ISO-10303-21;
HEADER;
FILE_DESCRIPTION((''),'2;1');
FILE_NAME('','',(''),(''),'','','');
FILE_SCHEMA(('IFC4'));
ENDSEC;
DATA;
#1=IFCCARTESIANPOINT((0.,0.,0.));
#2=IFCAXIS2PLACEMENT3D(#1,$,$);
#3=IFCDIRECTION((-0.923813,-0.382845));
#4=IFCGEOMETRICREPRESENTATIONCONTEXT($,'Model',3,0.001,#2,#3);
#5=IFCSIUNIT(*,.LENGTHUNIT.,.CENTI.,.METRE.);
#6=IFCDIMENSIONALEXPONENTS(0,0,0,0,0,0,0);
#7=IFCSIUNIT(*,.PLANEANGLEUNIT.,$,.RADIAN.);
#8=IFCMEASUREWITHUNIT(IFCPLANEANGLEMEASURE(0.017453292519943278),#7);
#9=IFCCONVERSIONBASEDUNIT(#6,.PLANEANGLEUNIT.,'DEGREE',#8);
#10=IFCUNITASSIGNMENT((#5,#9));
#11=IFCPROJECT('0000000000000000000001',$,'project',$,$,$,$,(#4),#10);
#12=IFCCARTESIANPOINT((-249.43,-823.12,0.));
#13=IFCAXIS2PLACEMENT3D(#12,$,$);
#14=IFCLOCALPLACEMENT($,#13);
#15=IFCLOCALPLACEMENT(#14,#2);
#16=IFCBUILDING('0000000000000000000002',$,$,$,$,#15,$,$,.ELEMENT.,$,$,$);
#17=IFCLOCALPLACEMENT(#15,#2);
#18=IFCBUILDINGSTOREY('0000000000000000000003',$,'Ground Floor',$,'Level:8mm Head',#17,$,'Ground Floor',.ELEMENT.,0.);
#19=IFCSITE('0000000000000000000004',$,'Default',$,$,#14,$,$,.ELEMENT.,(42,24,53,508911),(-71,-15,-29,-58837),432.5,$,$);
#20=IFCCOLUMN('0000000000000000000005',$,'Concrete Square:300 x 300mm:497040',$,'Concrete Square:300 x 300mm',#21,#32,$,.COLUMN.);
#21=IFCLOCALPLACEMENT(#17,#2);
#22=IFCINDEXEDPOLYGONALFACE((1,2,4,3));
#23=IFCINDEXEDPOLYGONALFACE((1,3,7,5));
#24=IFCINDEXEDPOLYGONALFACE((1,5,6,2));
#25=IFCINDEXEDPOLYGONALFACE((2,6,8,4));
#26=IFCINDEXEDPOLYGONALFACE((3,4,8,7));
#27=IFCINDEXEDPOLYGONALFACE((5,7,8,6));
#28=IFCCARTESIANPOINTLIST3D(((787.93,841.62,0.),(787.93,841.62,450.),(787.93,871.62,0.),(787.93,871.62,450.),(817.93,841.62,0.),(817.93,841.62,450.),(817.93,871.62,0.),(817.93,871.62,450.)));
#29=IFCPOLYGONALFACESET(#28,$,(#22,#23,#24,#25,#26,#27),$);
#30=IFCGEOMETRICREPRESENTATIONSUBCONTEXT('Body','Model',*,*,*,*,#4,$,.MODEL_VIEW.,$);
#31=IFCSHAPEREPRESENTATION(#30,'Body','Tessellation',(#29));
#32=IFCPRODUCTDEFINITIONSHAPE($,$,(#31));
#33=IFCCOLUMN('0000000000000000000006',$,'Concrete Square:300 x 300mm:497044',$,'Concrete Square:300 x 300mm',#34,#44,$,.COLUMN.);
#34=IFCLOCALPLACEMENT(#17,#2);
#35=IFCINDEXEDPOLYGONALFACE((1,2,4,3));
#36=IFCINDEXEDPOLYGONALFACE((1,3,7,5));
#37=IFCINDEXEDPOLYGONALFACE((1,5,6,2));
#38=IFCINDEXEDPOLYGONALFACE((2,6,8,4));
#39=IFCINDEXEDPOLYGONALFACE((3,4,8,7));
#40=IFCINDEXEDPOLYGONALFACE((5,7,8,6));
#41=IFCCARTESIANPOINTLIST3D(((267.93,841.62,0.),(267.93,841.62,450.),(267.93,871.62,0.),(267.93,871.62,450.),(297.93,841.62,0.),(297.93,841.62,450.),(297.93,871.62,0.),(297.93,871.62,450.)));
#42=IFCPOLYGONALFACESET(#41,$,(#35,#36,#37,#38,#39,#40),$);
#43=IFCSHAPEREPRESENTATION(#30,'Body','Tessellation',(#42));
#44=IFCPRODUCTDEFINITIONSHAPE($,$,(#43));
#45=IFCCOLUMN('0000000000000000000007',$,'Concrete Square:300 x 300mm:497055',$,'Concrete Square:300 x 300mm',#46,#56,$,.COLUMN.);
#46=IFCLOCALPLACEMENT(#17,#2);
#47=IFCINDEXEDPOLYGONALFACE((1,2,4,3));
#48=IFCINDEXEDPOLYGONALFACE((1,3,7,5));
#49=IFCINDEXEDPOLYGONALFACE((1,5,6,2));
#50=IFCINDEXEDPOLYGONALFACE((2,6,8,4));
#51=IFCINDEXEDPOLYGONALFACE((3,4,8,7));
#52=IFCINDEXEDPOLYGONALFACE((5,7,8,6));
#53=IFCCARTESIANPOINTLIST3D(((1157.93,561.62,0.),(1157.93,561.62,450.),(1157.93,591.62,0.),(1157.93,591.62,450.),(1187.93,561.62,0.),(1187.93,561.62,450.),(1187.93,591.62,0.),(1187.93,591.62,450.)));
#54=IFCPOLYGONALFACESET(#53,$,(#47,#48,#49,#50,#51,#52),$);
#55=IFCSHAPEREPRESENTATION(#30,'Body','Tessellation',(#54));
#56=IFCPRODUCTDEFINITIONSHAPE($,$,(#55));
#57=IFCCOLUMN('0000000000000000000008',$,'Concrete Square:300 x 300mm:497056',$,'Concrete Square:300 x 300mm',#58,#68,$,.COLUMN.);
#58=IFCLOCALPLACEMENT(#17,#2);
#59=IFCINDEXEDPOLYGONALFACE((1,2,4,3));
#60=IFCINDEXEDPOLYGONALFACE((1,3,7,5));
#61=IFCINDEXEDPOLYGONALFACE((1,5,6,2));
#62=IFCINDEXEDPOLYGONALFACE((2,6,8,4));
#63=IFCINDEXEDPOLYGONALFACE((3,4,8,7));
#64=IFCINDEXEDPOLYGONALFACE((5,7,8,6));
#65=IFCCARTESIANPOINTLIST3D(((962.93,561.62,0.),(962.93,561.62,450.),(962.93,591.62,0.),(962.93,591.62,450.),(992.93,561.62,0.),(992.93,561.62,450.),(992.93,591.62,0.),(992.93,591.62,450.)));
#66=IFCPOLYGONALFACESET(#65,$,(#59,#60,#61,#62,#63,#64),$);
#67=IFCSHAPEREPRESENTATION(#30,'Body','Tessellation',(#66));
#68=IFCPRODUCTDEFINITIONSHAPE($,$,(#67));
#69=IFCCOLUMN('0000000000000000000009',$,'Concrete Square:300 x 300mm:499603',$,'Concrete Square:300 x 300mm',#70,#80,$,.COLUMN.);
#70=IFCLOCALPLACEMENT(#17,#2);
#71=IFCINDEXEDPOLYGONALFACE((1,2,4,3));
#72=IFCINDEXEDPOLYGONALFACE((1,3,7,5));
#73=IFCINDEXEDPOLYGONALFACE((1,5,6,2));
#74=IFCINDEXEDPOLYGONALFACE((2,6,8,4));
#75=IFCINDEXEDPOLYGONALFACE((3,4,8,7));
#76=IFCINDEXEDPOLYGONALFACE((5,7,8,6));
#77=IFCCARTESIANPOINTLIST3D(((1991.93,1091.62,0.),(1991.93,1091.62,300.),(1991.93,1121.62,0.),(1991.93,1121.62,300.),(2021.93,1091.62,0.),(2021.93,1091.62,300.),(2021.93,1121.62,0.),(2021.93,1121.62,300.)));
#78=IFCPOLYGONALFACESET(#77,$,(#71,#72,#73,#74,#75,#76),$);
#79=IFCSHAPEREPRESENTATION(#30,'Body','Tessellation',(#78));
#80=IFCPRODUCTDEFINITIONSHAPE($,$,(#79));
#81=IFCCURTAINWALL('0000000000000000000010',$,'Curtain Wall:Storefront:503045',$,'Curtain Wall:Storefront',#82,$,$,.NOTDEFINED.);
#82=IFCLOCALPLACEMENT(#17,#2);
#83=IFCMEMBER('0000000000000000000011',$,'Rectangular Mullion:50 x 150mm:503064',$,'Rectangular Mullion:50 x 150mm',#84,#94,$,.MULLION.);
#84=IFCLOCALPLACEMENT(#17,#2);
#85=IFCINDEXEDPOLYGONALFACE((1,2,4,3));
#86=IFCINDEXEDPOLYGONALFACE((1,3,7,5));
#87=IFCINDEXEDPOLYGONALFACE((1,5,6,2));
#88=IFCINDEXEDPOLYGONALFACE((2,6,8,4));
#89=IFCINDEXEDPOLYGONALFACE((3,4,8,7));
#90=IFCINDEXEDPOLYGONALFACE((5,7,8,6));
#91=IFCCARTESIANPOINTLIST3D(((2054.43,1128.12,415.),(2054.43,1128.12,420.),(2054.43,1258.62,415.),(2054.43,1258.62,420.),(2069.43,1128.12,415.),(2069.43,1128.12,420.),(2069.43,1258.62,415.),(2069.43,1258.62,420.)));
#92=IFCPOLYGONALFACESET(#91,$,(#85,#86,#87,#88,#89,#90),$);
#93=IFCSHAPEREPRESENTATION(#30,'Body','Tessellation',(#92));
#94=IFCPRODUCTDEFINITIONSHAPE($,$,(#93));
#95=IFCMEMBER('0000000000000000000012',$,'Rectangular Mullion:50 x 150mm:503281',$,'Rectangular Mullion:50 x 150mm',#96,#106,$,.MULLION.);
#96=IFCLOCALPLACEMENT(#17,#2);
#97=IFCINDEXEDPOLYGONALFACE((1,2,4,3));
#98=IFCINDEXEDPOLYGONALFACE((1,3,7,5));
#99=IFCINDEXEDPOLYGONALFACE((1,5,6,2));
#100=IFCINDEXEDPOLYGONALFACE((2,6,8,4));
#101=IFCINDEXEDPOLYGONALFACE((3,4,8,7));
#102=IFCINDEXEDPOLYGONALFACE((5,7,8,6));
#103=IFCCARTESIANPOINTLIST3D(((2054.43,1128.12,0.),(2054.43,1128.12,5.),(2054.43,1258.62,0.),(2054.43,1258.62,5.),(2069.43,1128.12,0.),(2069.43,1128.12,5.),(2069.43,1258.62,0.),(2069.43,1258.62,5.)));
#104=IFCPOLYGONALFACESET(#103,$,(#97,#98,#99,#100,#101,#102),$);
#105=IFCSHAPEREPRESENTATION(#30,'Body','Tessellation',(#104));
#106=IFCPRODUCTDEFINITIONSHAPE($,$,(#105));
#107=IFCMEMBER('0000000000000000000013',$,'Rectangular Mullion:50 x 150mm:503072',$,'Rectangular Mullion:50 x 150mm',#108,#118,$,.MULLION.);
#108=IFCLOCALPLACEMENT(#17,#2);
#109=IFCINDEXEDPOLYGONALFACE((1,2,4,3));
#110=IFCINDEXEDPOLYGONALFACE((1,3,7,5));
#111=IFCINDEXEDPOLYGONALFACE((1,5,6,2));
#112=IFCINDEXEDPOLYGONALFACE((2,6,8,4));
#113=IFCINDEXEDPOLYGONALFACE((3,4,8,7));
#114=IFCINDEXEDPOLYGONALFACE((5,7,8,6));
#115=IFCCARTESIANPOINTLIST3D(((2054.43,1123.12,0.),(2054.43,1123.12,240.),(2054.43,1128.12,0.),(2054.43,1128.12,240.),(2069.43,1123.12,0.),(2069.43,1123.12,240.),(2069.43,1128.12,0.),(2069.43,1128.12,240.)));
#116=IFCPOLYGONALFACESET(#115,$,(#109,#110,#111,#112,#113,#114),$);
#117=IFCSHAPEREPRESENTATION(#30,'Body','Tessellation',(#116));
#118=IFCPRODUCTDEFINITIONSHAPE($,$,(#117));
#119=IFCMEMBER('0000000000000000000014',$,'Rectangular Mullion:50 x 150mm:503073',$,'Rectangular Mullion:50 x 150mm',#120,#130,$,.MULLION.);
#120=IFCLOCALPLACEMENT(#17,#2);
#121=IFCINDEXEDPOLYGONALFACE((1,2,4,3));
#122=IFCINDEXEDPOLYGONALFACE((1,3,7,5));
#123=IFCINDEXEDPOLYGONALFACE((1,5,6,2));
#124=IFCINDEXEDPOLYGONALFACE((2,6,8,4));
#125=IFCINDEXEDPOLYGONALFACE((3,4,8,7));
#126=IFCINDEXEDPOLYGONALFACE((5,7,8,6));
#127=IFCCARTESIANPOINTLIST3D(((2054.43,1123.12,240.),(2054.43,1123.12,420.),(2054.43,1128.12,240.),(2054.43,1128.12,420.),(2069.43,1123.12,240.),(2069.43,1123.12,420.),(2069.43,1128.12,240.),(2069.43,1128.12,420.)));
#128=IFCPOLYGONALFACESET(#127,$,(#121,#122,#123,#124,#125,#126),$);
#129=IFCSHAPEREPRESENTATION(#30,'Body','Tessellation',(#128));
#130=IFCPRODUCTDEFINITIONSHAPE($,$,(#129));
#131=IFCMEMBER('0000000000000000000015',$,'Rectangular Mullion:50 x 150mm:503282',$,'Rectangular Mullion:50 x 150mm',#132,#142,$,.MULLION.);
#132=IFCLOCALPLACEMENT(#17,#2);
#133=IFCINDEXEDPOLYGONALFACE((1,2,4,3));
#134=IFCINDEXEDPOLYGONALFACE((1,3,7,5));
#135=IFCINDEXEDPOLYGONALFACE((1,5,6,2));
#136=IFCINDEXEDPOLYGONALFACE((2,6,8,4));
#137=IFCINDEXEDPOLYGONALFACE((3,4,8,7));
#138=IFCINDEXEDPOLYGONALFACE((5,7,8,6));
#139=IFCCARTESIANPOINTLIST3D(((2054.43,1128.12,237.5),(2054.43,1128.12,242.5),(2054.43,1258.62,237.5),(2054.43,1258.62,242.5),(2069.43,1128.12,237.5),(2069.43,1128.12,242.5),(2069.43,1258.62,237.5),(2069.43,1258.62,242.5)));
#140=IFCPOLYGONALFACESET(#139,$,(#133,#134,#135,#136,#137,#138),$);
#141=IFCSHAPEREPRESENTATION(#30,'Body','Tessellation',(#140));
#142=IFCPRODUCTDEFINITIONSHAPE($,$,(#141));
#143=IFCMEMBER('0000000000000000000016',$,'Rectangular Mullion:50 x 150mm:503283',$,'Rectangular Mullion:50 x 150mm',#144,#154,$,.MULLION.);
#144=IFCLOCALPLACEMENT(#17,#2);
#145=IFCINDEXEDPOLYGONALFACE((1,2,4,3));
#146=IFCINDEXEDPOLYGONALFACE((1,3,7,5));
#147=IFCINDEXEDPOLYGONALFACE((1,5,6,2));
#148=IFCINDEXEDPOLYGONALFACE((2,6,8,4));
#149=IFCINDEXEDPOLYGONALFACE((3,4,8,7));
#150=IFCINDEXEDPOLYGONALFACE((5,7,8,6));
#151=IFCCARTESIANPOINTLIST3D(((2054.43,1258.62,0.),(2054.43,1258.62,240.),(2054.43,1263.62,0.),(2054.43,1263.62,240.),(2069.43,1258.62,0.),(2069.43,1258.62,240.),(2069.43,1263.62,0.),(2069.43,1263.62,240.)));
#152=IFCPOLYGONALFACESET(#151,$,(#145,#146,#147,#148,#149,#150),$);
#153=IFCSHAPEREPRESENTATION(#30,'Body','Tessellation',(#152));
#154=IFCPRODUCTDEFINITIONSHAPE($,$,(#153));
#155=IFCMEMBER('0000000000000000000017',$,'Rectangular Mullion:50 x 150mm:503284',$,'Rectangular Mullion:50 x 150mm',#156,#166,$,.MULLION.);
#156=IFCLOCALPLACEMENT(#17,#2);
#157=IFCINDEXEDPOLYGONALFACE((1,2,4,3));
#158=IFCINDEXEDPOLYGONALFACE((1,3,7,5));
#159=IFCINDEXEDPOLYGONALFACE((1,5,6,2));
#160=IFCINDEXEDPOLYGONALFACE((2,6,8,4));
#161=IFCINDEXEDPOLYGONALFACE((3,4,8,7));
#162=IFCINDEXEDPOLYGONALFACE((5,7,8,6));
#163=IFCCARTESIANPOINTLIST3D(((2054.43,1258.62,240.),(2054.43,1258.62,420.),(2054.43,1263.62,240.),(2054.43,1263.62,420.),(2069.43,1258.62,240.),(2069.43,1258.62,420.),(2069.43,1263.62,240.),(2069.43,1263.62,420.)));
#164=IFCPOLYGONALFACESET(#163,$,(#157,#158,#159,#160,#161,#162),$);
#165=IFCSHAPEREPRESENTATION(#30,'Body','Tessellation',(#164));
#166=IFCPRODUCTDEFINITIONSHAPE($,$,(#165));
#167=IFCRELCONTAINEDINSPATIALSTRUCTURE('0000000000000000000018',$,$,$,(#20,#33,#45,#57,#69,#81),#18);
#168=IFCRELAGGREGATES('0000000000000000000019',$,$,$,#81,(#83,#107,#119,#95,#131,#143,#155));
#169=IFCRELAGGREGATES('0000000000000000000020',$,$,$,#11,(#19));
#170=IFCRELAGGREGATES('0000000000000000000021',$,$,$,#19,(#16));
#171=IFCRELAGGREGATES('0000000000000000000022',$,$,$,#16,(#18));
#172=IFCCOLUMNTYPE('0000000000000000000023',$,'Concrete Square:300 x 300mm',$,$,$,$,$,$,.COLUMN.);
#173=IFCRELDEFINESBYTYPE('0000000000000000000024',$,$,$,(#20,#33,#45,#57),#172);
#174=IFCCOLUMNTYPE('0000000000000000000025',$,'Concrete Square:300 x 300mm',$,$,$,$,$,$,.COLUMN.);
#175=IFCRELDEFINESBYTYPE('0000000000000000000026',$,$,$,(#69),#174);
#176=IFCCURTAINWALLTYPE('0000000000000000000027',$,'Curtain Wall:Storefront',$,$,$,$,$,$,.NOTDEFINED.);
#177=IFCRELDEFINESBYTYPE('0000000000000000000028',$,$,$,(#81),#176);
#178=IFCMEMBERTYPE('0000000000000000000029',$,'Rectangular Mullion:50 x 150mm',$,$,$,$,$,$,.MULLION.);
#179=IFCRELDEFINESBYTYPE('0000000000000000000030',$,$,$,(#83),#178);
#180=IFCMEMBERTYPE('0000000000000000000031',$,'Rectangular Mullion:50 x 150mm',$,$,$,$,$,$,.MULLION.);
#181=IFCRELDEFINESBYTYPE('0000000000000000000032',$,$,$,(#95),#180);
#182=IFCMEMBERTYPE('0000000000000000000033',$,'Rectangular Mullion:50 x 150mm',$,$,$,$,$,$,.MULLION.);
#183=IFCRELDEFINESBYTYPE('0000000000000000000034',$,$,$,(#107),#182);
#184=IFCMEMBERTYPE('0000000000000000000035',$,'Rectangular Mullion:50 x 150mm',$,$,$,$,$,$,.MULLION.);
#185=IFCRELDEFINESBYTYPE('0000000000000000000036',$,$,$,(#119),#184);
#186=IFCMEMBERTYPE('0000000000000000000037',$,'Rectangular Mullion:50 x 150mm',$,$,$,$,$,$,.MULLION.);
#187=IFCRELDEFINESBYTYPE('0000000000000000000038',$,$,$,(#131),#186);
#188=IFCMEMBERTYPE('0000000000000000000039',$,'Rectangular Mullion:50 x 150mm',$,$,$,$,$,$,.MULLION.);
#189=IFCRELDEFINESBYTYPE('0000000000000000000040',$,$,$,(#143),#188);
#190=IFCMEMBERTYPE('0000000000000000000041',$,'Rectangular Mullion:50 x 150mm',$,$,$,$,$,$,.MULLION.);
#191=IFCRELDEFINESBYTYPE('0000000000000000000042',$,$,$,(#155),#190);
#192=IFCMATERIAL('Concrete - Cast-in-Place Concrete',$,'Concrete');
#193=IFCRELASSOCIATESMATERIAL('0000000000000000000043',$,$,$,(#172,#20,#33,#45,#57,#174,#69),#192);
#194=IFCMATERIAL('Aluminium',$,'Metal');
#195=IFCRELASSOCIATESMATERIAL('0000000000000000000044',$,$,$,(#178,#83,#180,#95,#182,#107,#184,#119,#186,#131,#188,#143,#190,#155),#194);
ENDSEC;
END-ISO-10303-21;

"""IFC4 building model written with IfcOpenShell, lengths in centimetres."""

from ifc_helpers import new_model, entity, si_unit, converted_unit, direction, frame, origin, place, context, subcontext, project, spatial, indexed_curve, outline, extrude, source, transform, mapped, material, type_object, type_shapes, element, aggregate, save


model = new_model("IFC4")

# Units and contexts
model_context = context("Model", 3, precision=0.001, world=origin(), true_north=direction((-0.923813, -0.382845)))
body_context = subcontext(model_context, "Body", "Model", "MODEL_VIEW")
ifc_project = project(units=[si_unit("LENGTHUNIT", "METRE", prefix="CENTI"), converted_unit("PLANEANGLEUNIT", "DEGREE", entity("IfcPlaneAngleMeasure", 0.017453292519943278), si_unit("PLANEANGLEUNIT", "RADIAN"), dimensions=[0, 0, 0, 0, 0, 0, 0])], contexts=[model_context])

# Site, building, storey
site_placement = place(None, frame((-249.43, -823.12, 0.0)))
site = spatial("IfcSite", under=ifc_project, at=site_placement, Name="Default", CompositionType="ELEMENT", RefLatitude=(42, 24, 53, 508911), RefLongitude=(-71, -15, -29, -58837), RefElevation=432.5)
building_placement = place(site_placement, origin())
building = spatial("IfcBuilding", under=site, at=building_placement, CompositionType="ELEMENT")
storey_placement = place(building_placement, origin())
storey = spatial("IfcBuildingStorey", under=building, at=storey_placement, Name="Ground Floor", ObjectType="Level:8mm Head", LongName="Ground Floor", CompositionType="ELEMENT", Elevation=0.0)

# Columns
ifc_material_1 = material(Name="Concrete - Cast-in-Place Concrete", Category="Concrete")
column_type_1 = type_object("IfcColumnType", Name="Concrete Square:300 x 300mm", PredefinedType="COLUMN", material=ifc_material_1)
shared_shape_1 = source(origin(), body_context, "Body", "SweptSolid", [
    extrude(outline(indexed_curve([(-15.0, -15.0), (15.0, -15.0), (15.0, 15.0), (-15.0, 15.0), (-15.0, -15.0)], self_intersect=False)), frame((0.0, 0.0, 0.0), z_axis=(0.0, 0.0, 1.0), x_axis=(-1.0, 0.0, 0.0)), (0.0, 0.0, 1.0), 450.0),
])
type_shapes(column_type_1, [shared_shape_1])
for number, where, name in (
    (1, (802.93, 856.62, 0.0), "Concrete Square:300 x 300mm:497040"),
    (2, (282.93, 856.62, 0.0), "Concrete Square:300 x 300mm:497044"),
    (3, (1172.93, 576.62, 0.0), "Concrete Square:300 x 300mm:497055"),
    (4, (977.93, 576.62, 0.0), "Concrete Square:300 x 300mm:497056"),
):
    element("IfcColumn", number, at=place(storey_placement, frame(where)), inside=storey, type_object=column_type_1, material=ifc_material_1, Name=name, ObjectType="Concrete Square:300 x 300mm", PredefinedType="COLUMN", context=body_context, shape_type="MappedRepresentation", body=[
        mapped(shared_shape_1, transform((0.0, 0.0, 0.0), scale=1.0)),
    ])
column_type_2 = type_object("IfcColumnType", Name="Concrete Square:300 x 300mm", PredefinedType="COLUMN", material=ifc_material_1)
shared_shape_2 = source(origin(), body_context, "Body", "SweptSolid", [
    extrude(outline(indexed_curve([(-15.0, -15.0), (15.0, -15.0), (15.0, 15.0), (-15.0, 15.0), (-15.0, -15.0)], self_intersect=False)), frame((0.0, 0.0, 0.0), z_axis=(0.0, 0.0, 1.0), x_axis=(-1.0, 0.0, 0.0)), (0.0, 0.0, 1.0), 300.0),
])
type_shapes(column_type_2, [shared_shape_2])
column_placement = place(storey_placement, frame((2006.93, 1106.62, 0.0)))
element("IfcColumn", 5, at=column_placement, inside=storey, type_object=column_type_2, material=ifc_material_1, Name="Concrete Square:300 x 300mm:499603", ObjectType="Concrete Square:300 x 300mm", PredefinedType="COLUMN", context=body_context, shape_type="MappedRepresentation", body=[
    mapped(shared_shape_2, transform((0.0, 0.0, 0.0), scale=1.0)),
])

# Curtain wall, members
curtain_wall_type = type_object("IfcCurtainWallType", Name="Curtain Wall:Storefront", PredefinedType="NOTDEFINED")
curtain_wall_placement = place(storey_placement, origin())
curtain_wall = element("IfcCurtainWall", 6, at=curtain_wall_placement, inside=storey, type_object=curtain_wall_type, Name="Curtain Wall:Storefront:503045", ObjectType="Curtain Wall:Storefront", PredefinedType="NOTDEFINED")
ifc_material_2 = material(Name="Aluminium", Category="Metal")
member_type_1 = type_object("IfcMemberType", Name="Rectangular Mullion:50 x 150mm", PredefinedType="MULLION", material=ifc_material_2)
shared_shape_3 = source(origin(), body_context, "Body", "SweptSolid", [
    extrude(outline(indexed_curve([(-2.5, -7.5), (2.5, -7.5), (2.5, 7.5), (-2.5, 7.5), (-2.5, -7.5)], self_intersect=False)), frame((-2.5, 0.0, -130.5), z_axis=(0.0, 0.0, 1.0), x_axis=(-1.0, 0.0, 0.0)), (0.0, 0.0, 1.0), 130.5),
])
type_shapes(member_type_1, [shared_shape_3])
member_1_placement = place(curtain_wall_placement, frame((2061.93, 1128.12, 420.0), z_axis=(0.0, -1.0, 0.0), x_axis=(0.0, 0.0, 1.0)))
member_1 = element("IfcMember", 7, at=member_1_placement, type_object=member_type_1, material=ifc_material_2, Name="Rectangular Mullion:50 x 150mm:503064", ObjectType="Rectangular Mullion:50 x 150mm", PredefinedType="MULLION", context=body_context, shape_type="MappedRepresentation", body=[
    mapped(shared_shape_3, transform((0.0, 0.0, 0.0), scale=1.0)),
])
member_type_2 = type_object("IfcMemberType", Name="Rectangular Mullion:50 x 150mm", PredefinedType="MULLION", material=ifc_material_2)
shared_shape_4 = source(origin(), body_context, "Body", "SweptSolid", [
    extrude(outline(indexed_curve([(-2.5, -7.5), (2.5, -7.5), (2.5, 7.5), (-2.5, 7.5), (-2.5, -7.5)], self_intersect=False)), frame((-2.5, 0.0, -130.5), z_axis=(0.0, 0.0, 1.0), x_axis=(-1.0, 0.0, 0.0)), (0.0, 0.0, 1.0), 130.5),
])
type_shapes(member_type_2, [shared_shape_4])
member_2_placement = place(curtain_wall_placement, frame((2061.93, 1258.62, 0.0), z_axis=(0.0, 1.0, 0.0), x_axis=(0.0, 0.0, -1.0)))
member_2 = element("IfcMember", 8, at=member_2_placement, type_object=member_type_2, material=ifc_material_2, Name="Rectangular Mullion:50 x 150mm:503281", ObjectType="Rectangular Mullion:50 x 150mm", PredefinedType="MULLION", context=body_context, shape_type="MappedRepresentation", body=[
    mapped(shared_shape_4, transform((0.0, 0.0, 0.0), scale=1.0)),
])
member_type_3 = type_object("IfcMemberType", Name="Rectangular Mullion:50 x 150mm", PredefinedType="MULLION", material=ifc_material_2)
shared_shape_5 = source(origin(), body_context, "Body", "SweptSolid", [
    extrude(outline(indexed_curve([(-2.5, -7.5), (2.5, -7.5), (2.5, 7.5), (-2.5, 7.5), (-2.5, -7.5)], self_intersect=False)), frame((-2.5, 0.0, -240.0), z_axis=(0.0, 0.0, 1.0), x_axis=(-1.0, 0.0, 0.0)), (0.0, 0.0, 1.0), 240.0),
])
type_shapes(member_type_3, [shared_shape_5])
member_3_placement = place(curtain_wall_placement, frame((2061.93, 1123.12, 0.0), z_axis=(0.0, 0.0, -1.0), x_axis=(0.0, -1.0, 0.0)))
member_3 = element("IfcMember", 9, at=member_3_placement, type_object=member_type_3, material=ifc_material_2, Name="Rectangular Mullion:50 x 150mm:503072", ObjectType="Rectangular Mullion:50 x 150mm", PredefinedType="MULLION", context=body_context, shape_type="MappedRepresentation", body=[
    mapped(shared_shape_5, transform((0.0, 0.0, 0.0), scale=1.0)),
])
member_type_4 = type_object("IfcMemberType", Name="Rectangular Mullion:50 x 150mm", PredefinedType="MULLION", material=ifc_material_2)
shared_shape_6 = source(origin(), body_context, "Body", "SweptSolid", [
    extrude(outline(indexed_curve([(-2.5, -7.5), (2.5, -7.5), (2.5, 7.5), (-2.5, 7.5), (-2.5, -7.5)], self_intersect=False)), frame((-2.5, 0.0, -180.0), z_axis=(0.0, 0.0, 1.0), x_axis=(-1.0, 0.0, 0.0)), (0.0, 0.0, 1.0), 180.0),
])
type_shapes(member_type_4, [shared_shape_6])
member_4_placement = place(curtain_wall_placement, frame((2061.93, 1123.12, 240.0), z_axis=(0.0, 0.0, -1.0), x_axis=(0.0, -1.0, 0.0)))
member_4 = element("IfcMember", 10, at=member_4_placement, type_object=member_type_4, material=ifc_material_2, Name="Rectangular Mullion:50 x 150mm:503073", ObjectType="Rectangular Mullion:50 x 150mm", PredefinedType="MULLION", context=body_context, shape_type="MappedRepresentation", body=[
    mapped(shared_shape_6, transform((0.0, 0.0, 0.0), scale=1.0)),
])
member_type_5 = type_object("IfcMemberType", Name="Rectangular Mullion:50 x 150mm", PredefinedType="MULLION", material=ifc_material_2)
shared_shape_7 = source(origin(), body_context, "Body", "SweptSolid", [
    extrude(outline(indexed_curve([(-2.5, -7.5), (2.5, -7.5), (2.5, 7.5), (-2.5, 7.5), (-2.5, -7.5)], self_intersect=False)), frame((0.0, 0.0, -130.5), z_axis=(0.0, 0.0, 1.0), x_axis=(-1.0, 0.0, 0.0)), (0.0, 0.0, 1.0), 130.5),
])
type_shapes(member_type_5, [shared_shape_7])
member_5_placement = place(curtain_wall_placement, frame((2061.93, 1128.12, 240.0), z_axis=(0.0, -1.0, 0.0), x_axis=(0.0, 0.0, 1.0)))
member_5 = element("IfcMember", 11, at=member_5_placement, type_object=member_type_5, material=ifc_material_2, Name="Rectangular Mullion:50 x 150mm:503282", ObjectType="Rectangular Mullion:50 x 150mm", PredefinedType="MULLION", context=body_context, shape_type="MappedRepresentation", body=[
    mapped(shared_shape_7, transform((0.0, 0.0, 0.0), scale=1.0)),
])
member_type_6 = type_object("IfcMemberType", Name="Rectangular Mullion:50 x 150mm", PredefinedType="MULLION", material=ifc_material_2)
shared_shape_8 = source(origin(), body_context, "Body", "SweptSolid", [
    extrude(outline(indexed_curve([(-2.5, -7.5), (2.5, -7.5), (2.5, 7.5), (-2.5, 7.5), (-2.5, -7.5)], self_intersect=False)), frame((0.0, 0.0, -240.0), z_axis=(0.0, 0.0, 1.0), x_axis=(-1.0, 0.0, 0.0)), (0.0, 0.0, 1.0), 240.0),
])
type_shapes(member_type_6, [shared_shape_8])
member_6_placement = place(curtain_wall_placement, frame((2061.93, 1261.12, 0.0), z_axis=(0.0, 0.0, -1.0), x_axis=(0.0, -1.0, 0.0)))
member_6 = element("IfcMember", 12, at=member_6_placement, type_object=member_type_6, material=ifc_material_2, Name="Rectangular Mullion:50 x 150mm:503283", ObjectType="Rectangular Mullion:50 x 150mm", PredefinedType="MULLION", context=body_context, shape_type="MappedRepresentation", body=[
    mapped(shared_shape_8, transform((0.0, 0.0, 0.0), scale=1.0)),
])
member_type_7 = type_object("IfcMemberType", Name="Rectangular Mullion:50 x 150mm", PredefinedType="MULLION", material=ifc_material_2)
shared_shape_9 = source(origin(), body_context, "Body", "SweptSolid", [
    extrude(outline(indexed_curve([(-2.5, -7.5), (2.5, -7.5), (2.5, 7.5), (-2.5, 7.5), (-2.5, -7.5)], self_intersect=False)), frame((0.0, 0.0, -180.0), z_axis=(0.0, 0.0, 1.0), x_axis=(-1.0, 0.0, 0.0)), (0.0, 0.0, 1.0), 180.0),
])
type_shapes(member_type_7, [shared_shape_9])
member_7_placement = place(curtain_wall_placement, frame((2061.93, 1261.12, 240.0), z_axis=(0.0, 0.0, -1.0), x_axis=(0.0, -1.0, 0.0)))
member_7 = element("IfcMember", 13, at=member_7_placement, type_object=member_type_7, material=ifc_material_2, Name="Rectangular Mullion:50 x 150mm:503284", ObjectType="Rectangular Mullion:50 x 150mm", PredefinedType="MULLION", context=body_context, shape_type="MappedRepresentation", body=[
    mapped(shared_shape_9, transform((0.0, 0.0, 0.0), scale=1.0)),
])

aggregate(curtain_wall, [member_1, member_3, member_4, member_2, member_5, member_6, member_7])

save(model, "model.ifc")
